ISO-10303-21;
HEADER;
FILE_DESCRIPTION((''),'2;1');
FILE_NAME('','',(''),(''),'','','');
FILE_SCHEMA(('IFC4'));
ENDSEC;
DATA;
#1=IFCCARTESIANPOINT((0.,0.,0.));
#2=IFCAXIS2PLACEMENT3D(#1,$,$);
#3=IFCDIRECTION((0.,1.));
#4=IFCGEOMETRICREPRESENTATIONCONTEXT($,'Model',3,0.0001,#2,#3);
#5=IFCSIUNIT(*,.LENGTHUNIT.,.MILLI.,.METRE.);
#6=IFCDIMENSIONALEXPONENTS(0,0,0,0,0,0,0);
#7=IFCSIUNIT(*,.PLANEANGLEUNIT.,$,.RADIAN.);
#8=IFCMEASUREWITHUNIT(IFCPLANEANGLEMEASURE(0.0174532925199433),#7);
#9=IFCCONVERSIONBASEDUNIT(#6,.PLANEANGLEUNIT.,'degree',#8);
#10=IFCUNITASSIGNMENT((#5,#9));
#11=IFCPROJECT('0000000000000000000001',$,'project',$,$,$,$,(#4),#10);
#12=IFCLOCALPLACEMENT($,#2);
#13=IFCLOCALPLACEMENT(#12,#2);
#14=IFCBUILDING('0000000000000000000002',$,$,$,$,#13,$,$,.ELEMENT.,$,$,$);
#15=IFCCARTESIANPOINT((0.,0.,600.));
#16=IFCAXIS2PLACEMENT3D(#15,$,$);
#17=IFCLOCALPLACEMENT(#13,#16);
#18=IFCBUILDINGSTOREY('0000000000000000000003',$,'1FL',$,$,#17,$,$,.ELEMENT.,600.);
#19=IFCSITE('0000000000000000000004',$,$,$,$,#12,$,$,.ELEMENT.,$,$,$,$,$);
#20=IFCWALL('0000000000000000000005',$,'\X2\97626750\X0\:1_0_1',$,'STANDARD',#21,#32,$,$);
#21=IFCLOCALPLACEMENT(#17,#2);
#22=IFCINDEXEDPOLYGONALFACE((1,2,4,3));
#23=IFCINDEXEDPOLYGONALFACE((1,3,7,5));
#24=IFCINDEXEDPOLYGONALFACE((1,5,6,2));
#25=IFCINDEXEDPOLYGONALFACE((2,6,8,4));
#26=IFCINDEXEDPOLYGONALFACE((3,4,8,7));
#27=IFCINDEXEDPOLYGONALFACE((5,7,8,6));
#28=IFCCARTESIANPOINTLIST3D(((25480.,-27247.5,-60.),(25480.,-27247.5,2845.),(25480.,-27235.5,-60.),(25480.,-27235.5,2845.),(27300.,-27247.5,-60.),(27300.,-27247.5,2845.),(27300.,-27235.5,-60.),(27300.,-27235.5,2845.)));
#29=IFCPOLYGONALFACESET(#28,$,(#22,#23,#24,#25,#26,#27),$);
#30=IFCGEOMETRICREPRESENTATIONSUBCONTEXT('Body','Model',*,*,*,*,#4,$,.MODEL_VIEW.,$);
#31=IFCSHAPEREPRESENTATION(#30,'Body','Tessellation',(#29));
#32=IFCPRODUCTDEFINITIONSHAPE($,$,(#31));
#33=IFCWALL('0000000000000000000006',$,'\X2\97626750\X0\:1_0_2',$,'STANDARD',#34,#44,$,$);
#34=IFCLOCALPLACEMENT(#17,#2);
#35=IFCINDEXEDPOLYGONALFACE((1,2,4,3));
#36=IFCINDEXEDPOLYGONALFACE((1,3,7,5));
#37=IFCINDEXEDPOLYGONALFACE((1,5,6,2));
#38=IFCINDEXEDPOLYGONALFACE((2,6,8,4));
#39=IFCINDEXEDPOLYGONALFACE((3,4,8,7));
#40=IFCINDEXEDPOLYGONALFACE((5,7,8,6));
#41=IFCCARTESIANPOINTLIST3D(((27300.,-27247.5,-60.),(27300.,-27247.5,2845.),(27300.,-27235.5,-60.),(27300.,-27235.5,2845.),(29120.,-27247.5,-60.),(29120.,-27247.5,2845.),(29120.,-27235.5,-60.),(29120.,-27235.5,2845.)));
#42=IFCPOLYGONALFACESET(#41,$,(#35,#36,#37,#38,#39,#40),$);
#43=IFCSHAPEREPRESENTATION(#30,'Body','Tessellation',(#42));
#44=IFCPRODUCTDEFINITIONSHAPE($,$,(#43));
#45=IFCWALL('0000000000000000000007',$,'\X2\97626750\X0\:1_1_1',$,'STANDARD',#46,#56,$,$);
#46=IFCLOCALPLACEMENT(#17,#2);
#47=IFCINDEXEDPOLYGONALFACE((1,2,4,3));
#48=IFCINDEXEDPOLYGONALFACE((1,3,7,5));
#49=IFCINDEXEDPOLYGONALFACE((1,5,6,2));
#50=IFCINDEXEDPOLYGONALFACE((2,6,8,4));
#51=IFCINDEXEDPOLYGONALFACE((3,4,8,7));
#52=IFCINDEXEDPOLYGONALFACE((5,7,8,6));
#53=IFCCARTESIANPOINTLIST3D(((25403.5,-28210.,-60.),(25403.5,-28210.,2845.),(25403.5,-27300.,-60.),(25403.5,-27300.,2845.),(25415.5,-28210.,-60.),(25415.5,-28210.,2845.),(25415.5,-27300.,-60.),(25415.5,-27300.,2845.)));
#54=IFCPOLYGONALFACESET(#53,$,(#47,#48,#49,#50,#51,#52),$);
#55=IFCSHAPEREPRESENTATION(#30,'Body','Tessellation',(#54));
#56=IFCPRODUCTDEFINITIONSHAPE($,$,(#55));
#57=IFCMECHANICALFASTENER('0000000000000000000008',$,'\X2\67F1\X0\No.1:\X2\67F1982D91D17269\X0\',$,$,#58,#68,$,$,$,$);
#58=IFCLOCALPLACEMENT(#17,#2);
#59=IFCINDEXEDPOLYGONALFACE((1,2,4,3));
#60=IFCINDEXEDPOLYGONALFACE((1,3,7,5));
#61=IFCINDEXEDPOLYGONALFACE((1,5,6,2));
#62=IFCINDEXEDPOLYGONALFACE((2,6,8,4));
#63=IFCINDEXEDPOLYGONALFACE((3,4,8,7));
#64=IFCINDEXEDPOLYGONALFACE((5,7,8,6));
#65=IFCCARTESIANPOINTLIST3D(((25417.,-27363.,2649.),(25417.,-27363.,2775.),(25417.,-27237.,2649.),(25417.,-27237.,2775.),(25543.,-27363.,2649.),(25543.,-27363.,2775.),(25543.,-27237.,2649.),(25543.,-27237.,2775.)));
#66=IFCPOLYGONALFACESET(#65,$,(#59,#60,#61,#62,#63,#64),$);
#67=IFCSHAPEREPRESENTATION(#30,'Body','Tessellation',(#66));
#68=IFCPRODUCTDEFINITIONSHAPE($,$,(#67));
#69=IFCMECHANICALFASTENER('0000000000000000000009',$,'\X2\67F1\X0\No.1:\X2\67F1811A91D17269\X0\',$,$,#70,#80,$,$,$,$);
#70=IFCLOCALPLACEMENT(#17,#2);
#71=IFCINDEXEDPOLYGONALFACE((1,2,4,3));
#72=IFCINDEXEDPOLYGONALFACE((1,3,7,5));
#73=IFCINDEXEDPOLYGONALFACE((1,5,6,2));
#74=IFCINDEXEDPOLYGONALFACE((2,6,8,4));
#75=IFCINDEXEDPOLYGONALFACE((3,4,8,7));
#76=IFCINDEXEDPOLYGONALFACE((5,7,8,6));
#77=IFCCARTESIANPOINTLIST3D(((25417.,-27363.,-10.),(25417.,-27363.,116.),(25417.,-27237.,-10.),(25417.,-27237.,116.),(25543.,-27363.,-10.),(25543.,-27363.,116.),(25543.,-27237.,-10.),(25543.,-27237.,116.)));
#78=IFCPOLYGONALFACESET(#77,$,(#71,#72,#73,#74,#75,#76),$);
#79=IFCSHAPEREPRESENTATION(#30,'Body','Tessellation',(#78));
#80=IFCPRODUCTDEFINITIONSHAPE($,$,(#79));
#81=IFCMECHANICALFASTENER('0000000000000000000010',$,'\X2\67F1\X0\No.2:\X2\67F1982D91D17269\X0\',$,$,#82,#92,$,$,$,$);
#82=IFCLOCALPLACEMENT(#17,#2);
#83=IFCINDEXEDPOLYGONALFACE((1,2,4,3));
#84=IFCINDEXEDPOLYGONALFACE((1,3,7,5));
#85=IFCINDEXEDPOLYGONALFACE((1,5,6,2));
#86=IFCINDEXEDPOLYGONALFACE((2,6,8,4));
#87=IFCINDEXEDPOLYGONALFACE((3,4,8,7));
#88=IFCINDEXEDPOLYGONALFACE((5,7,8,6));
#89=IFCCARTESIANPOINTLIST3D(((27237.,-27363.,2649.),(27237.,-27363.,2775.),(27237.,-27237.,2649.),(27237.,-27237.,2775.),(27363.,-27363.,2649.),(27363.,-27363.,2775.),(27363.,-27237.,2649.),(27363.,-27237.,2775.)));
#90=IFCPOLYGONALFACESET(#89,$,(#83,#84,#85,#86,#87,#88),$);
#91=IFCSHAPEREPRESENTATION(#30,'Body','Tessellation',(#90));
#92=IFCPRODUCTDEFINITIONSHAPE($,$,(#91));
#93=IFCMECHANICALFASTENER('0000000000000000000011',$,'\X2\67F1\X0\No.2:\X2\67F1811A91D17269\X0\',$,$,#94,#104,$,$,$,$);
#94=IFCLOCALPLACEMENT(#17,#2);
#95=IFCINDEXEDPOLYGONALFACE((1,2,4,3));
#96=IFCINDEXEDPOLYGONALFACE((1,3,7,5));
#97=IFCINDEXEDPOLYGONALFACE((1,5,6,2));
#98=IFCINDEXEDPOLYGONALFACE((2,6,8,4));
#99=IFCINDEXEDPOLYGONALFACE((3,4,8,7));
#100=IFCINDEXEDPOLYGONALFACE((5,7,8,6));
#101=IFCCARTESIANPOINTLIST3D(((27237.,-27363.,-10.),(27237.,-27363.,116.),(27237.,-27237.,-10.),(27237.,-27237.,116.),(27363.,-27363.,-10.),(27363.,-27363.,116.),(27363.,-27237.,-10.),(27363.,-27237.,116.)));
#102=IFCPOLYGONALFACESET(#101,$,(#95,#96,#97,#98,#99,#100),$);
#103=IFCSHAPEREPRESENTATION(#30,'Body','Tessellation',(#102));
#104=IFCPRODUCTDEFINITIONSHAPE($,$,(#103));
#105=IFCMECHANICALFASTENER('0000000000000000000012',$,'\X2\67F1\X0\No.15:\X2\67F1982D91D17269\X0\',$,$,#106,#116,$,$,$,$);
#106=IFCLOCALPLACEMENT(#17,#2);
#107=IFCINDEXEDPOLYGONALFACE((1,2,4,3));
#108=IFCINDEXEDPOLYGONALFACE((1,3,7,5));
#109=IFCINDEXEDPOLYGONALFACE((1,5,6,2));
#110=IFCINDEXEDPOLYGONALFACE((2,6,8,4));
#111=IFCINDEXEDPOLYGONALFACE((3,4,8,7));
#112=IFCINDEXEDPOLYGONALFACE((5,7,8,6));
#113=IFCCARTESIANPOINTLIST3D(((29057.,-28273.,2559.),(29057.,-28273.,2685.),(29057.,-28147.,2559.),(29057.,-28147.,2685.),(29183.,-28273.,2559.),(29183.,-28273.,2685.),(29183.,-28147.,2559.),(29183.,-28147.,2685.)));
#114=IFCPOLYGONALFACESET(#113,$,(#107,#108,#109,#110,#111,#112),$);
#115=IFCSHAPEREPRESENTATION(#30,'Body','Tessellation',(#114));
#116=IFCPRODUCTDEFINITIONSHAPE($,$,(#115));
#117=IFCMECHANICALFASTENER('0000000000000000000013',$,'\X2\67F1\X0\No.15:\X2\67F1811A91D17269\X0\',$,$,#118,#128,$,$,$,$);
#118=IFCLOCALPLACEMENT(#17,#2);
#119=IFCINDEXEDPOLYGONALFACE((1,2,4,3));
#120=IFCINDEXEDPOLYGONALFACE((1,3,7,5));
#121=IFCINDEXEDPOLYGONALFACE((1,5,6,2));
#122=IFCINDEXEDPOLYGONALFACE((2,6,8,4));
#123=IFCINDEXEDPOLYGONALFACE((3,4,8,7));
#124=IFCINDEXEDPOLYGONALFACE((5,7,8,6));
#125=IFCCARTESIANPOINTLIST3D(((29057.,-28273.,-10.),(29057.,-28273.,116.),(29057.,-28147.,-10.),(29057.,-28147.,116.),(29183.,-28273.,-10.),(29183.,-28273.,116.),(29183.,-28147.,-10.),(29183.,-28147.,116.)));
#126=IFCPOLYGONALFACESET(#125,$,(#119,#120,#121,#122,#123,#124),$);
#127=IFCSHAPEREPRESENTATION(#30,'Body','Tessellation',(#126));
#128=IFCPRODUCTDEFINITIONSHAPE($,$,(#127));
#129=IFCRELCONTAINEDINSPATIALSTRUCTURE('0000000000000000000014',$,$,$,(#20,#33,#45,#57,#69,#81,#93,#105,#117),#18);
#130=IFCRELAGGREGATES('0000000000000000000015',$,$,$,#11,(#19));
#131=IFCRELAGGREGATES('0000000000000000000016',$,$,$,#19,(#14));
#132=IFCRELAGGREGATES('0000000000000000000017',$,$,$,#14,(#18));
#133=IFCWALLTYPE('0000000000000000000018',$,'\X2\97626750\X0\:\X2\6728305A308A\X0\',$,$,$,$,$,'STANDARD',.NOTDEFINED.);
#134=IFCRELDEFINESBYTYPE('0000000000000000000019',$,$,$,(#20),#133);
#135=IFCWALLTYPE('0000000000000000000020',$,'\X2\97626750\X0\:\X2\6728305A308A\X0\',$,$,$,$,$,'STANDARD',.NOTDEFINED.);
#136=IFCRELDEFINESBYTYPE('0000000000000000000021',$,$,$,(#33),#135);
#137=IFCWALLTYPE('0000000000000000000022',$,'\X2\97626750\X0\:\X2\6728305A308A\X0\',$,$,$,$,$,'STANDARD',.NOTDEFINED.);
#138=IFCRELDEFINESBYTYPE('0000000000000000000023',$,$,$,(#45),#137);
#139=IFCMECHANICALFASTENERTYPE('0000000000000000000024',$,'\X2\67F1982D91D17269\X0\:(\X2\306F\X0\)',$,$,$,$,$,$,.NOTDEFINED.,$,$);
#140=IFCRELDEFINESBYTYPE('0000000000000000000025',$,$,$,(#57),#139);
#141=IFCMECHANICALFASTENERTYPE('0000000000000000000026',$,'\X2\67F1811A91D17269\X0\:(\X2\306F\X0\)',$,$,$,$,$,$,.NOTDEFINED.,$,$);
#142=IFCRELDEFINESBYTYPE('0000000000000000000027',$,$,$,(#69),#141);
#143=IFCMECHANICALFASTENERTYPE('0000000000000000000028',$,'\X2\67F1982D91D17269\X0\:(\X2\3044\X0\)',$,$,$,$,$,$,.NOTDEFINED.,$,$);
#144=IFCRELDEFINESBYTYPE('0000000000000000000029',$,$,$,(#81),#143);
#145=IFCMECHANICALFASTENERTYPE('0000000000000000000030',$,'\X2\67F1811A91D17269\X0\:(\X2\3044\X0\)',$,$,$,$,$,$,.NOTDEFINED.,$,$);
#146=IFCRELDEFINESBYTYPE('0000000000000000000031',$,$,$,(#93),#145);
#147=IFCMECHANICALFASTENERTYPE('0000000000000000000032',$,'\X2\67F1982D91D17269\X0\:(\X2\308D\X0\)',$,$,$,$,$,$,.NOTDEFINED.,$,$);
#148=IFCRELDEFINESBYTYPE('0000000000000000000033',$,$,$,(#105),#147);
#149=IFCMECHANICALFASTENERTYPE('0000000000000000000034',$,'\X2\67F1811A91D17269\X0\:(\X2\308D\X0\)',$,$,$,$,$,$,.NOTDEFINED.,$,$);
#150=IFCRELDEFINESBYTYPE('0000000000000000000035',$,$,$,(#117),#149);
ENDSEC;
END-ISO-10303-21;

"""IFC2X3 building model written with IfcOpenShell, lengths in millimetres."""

from ifc_helpers import new_model, entity, si_unit, converted_unit, direction, frame, origin, origin_with_axes, origin_2d, place, context, subcontext, project, spatial, polyline, rectangle, outline, extrude, type_object, element, save


model = new_model("IFC2X3")

# Units and contexts
model_context = context("Model", 3, precision=0.0001, world=origin(), true_north=direction((0.0, 1.0)))
body_context = subcontext(model_context, "Body", "Model", "MODEL_VIEW")
ifc_project = project(units=[si_unit("LENGTHUNIT", "METRE", prefix="MILLI"), converted_unit("PLANEANGLEUNIT", "degree", entity("IfcPlaneAngleMeasure", 0.0174532925199433), si_unit("PLANEANGLEUNIT", "RADIAN"), dimensions=[0, 0, 0, 0, 0, 0, 0])], contexts=[model_context])

# Site, building, storey
site_placement = place(None, origin())
site = spatial("IfcSite", under=ifc_project, at=site_placement, CompositionType="ELEMENT")
building_placement = place(site_placement, origin())
building = spatial("IfcBuilding", under=site, at=building_placement, CompositionType="ELEMENT")
storey_placement = place(building_placement, frame((0.0, 0.0, 600.0)))
storey = spatial("IfcBuildingStorey", under=building, at=storey_placement, Name="1FL", CompositionType="ELEMENT", Elevation=600.0)

# Walls
wall_type_1 = type_object("IfcWallType", Name="面材:木ずり", ElementType="STANDARD", PredefinedType="NOTDEFINED")
wall_1_placement = place(storey_placement, frame((26390.0, -27235.5, -60.0), z_axis=(0.0, -1.0, 0.0), x_axis=(1.0, 0.0, 0.0)))
element("IfcWall", 1, at=wall_1_placement, inside=storey, type_object=wall_type_1, Name="面材:1_0_1", ObjectType="STANDARD", context=body_context, shape_type="SweptSolid", body=[
    extrude(outline(polyline([(910.0, 0.0, 0.0), (-910.0, 0.0, 0.0), (-910.0, 2905.0, 0.0), (910.0, 2905.0, 0.0), (910.0, 0.0, 0.0)])), origin_with_axes(), (0.0, 0.0, 1.0), 12.0),
])
wall_type_2 = type_object("IfcWallType", Name="面材:木ずり", ElementType="STANDARD", PredefinedType="NOTDEFINED")
wall_2_placement = place(storey_placement, frame((28210.0, -27235.5, -60.0), z_axis=(0.0, -1.0, 0.0), x_axis=(1.0, 0.0, 0.0)))
element("IfcWall", 2, at=wall_2_placement, inside=storey, type_object=wall_type_2, Name="面材:1_0_2", ObjectType="STANDARD", context=body_context, shape_type="SweptSolid", body=[
    extrude(outline(polyline([(910.0, 0.0, 0.0), (-910.0, 0.0, 0.0), (-910.0, 2905.0, 0.0), (910.0, 2905.0, 0.0), (910.0, 0.0, 0.0)])), origin_with_axes(), (0.0, 0.0, 1.0), 12.0),
])
wall_type_3 = type_object("IfcWallType", Name="面材:木ずり", ElementType="STANDARD", PredefinedType="NOTDEFINED")
wall_3_placement = place(storey_placement, frame((25415.5, -27755.0, -60.0), z_axis=(-1.0, 0.0, 0.0), x_axis=(0.0, -1.0, 0.0)))
element("IfcWall", 3, at=wall_3_placement, inside=storey, type_object=wall_type_3, Name="面材:1_1_1", ObjectType="STANDARD", context=body_context, shape_type="SweptSolid", body=[
    extrude(outline(polyline([(455.0, 0.0, 0.0), (-455.0, 0.0, 0.0), (-455.0, 2905.0, 0.0), (455.0, 2905.0, 0.0), (455.0, 0.0, 0.0)])), origin_with_axes(), (0.0, 0.0, 1.0), 12.0),
])

# Mechanical fasteners
mechanical_fastener_type_1 = type_object("IfcMechanicalFastenerType", Name="柱頭金物:(は)")
mechanical_fastener_1_placement = place(storey_placement, frame((25480.0, -27300.0, 2649.0)))
element("IfcMechanicalFastener", 4, at=mechanical_fastener_1_placement, inside=storey, type_object=mechanical_fastener_type_1, Name="柱No.1:柱頭金物", context=body_context, shape_type="SweptSolid", body=[
    extrude(rectangle(XDim=126.0, YDim=126.0, at=origin_2d()), origin_with_axes(), (0.0, 0.0, 1.0), 126.0),
])
mechanical_fastener_type_2 = type_object("IfcMechanicalFastenerType", Name="柱脚金物:(は)")
mechanical_fastener_2_placement = place(storey_placement, frame((25480.0, -27300.0, -10.0)))
element("IfcMechanicalFastener", 5, at=mechanical_fastener_2_placement, inside=storey, type_object=mechanical_fastener_type_2, Name="柱No.1:柱脚金物", context=body_context, shape_type="SweptSolid", body=[
    extrude(rectangle(XDim=126.0, YDim=126.0, at=origin_2d()), origin_with_axes(), (0.0, 0.0, 1.0), 126.0),
])
mechanical_fastener_type_3 = type_object("IfcMechanicalFastenerType", Name="柱頭金物:(い)")
mechanical_fastener_3_placement = place(storey_placement, frame((27300.0, -27300.0, 2649.0)))
element("IfcMechanicalFastener", 6, at=mechanical_fastener_3_placement, inside=storey, type_object=mechanical_fastener_type_3, Name="柱No.2:柱頭金物", context=body_context, shape_type="SweptSolid", body=[
    extrude(rectangle(XDim=126.0, YDim=126.0, at=origin_2d()), origin_with_axes(), (0.0, 0.0, 1.0), 126.0),
])
mechanical_fastener_type_4 = type_object("IfcMechanicalFastenerType", Name="柱脚金物:(い)")
mechanical_fastener_4_placement = place(storey_placement, frame((27300.0, -27300.0, -10.0)))
element("IfcMechanicalFastener", 7, at=mechanical_fastener_4_placement, inside=storey, type_object=mechanical_fastener_type_4, Name="柱No.2:柱脚金物", context=body_context, shape_type="SweptSolid", body=[
    extrude(rectangle(XDim=126.0, YDim=126.0, at=origin_2d()), origin_with_axes(), (0.0, 0.0, 1.0), 126.0),
])
mechanical_fastener_type_5 = type_object("IfcMechanicalFastenerType", Name="柱頭金物:(ろ)")
mechanical_fastener_5_placement = place(storey_placement, frame((29120.0, -28210.0, 2559.0)))
element("IfcMechanicalFastener", 8, at=mechanical_fastener_5_placement, inside=storey, type_object=mechanical_fastener_type_5, Name="柱No.15:柱頭金物", context=body_context, shape_type="SweptSolid", body=[
    extrude(rectangle(XDim=126.0, YDim=126.0, at=origin_2d()), origin_with_axes(), (0.0, 0.0, 1.0), 126.0),
])
mechanical_fastener_type_6 = type_object("IfcMechanicalFastenerType", Name="柱脚金物:(ろ)")
mechanical_fastener_6_placement = place(storey_placement, frame((29120.0, -28210.0, -10.0)))
element("IfcMechanicalFastener", 9, at=mechanical_fastener_6_placement, inside=storey, type_object=mechanical_fastener_type_6, Name="柱No.15:柱脚金物", context=body_context, shape_type="SweptSolid", body=[
    extrude(rectangle(XDim=126.0, YDim=126.0, at=origin_2d()), origin_with_axes(), (0.0, 0.0, 1.0), 126.0),
])

save(model, "model.ifc")
